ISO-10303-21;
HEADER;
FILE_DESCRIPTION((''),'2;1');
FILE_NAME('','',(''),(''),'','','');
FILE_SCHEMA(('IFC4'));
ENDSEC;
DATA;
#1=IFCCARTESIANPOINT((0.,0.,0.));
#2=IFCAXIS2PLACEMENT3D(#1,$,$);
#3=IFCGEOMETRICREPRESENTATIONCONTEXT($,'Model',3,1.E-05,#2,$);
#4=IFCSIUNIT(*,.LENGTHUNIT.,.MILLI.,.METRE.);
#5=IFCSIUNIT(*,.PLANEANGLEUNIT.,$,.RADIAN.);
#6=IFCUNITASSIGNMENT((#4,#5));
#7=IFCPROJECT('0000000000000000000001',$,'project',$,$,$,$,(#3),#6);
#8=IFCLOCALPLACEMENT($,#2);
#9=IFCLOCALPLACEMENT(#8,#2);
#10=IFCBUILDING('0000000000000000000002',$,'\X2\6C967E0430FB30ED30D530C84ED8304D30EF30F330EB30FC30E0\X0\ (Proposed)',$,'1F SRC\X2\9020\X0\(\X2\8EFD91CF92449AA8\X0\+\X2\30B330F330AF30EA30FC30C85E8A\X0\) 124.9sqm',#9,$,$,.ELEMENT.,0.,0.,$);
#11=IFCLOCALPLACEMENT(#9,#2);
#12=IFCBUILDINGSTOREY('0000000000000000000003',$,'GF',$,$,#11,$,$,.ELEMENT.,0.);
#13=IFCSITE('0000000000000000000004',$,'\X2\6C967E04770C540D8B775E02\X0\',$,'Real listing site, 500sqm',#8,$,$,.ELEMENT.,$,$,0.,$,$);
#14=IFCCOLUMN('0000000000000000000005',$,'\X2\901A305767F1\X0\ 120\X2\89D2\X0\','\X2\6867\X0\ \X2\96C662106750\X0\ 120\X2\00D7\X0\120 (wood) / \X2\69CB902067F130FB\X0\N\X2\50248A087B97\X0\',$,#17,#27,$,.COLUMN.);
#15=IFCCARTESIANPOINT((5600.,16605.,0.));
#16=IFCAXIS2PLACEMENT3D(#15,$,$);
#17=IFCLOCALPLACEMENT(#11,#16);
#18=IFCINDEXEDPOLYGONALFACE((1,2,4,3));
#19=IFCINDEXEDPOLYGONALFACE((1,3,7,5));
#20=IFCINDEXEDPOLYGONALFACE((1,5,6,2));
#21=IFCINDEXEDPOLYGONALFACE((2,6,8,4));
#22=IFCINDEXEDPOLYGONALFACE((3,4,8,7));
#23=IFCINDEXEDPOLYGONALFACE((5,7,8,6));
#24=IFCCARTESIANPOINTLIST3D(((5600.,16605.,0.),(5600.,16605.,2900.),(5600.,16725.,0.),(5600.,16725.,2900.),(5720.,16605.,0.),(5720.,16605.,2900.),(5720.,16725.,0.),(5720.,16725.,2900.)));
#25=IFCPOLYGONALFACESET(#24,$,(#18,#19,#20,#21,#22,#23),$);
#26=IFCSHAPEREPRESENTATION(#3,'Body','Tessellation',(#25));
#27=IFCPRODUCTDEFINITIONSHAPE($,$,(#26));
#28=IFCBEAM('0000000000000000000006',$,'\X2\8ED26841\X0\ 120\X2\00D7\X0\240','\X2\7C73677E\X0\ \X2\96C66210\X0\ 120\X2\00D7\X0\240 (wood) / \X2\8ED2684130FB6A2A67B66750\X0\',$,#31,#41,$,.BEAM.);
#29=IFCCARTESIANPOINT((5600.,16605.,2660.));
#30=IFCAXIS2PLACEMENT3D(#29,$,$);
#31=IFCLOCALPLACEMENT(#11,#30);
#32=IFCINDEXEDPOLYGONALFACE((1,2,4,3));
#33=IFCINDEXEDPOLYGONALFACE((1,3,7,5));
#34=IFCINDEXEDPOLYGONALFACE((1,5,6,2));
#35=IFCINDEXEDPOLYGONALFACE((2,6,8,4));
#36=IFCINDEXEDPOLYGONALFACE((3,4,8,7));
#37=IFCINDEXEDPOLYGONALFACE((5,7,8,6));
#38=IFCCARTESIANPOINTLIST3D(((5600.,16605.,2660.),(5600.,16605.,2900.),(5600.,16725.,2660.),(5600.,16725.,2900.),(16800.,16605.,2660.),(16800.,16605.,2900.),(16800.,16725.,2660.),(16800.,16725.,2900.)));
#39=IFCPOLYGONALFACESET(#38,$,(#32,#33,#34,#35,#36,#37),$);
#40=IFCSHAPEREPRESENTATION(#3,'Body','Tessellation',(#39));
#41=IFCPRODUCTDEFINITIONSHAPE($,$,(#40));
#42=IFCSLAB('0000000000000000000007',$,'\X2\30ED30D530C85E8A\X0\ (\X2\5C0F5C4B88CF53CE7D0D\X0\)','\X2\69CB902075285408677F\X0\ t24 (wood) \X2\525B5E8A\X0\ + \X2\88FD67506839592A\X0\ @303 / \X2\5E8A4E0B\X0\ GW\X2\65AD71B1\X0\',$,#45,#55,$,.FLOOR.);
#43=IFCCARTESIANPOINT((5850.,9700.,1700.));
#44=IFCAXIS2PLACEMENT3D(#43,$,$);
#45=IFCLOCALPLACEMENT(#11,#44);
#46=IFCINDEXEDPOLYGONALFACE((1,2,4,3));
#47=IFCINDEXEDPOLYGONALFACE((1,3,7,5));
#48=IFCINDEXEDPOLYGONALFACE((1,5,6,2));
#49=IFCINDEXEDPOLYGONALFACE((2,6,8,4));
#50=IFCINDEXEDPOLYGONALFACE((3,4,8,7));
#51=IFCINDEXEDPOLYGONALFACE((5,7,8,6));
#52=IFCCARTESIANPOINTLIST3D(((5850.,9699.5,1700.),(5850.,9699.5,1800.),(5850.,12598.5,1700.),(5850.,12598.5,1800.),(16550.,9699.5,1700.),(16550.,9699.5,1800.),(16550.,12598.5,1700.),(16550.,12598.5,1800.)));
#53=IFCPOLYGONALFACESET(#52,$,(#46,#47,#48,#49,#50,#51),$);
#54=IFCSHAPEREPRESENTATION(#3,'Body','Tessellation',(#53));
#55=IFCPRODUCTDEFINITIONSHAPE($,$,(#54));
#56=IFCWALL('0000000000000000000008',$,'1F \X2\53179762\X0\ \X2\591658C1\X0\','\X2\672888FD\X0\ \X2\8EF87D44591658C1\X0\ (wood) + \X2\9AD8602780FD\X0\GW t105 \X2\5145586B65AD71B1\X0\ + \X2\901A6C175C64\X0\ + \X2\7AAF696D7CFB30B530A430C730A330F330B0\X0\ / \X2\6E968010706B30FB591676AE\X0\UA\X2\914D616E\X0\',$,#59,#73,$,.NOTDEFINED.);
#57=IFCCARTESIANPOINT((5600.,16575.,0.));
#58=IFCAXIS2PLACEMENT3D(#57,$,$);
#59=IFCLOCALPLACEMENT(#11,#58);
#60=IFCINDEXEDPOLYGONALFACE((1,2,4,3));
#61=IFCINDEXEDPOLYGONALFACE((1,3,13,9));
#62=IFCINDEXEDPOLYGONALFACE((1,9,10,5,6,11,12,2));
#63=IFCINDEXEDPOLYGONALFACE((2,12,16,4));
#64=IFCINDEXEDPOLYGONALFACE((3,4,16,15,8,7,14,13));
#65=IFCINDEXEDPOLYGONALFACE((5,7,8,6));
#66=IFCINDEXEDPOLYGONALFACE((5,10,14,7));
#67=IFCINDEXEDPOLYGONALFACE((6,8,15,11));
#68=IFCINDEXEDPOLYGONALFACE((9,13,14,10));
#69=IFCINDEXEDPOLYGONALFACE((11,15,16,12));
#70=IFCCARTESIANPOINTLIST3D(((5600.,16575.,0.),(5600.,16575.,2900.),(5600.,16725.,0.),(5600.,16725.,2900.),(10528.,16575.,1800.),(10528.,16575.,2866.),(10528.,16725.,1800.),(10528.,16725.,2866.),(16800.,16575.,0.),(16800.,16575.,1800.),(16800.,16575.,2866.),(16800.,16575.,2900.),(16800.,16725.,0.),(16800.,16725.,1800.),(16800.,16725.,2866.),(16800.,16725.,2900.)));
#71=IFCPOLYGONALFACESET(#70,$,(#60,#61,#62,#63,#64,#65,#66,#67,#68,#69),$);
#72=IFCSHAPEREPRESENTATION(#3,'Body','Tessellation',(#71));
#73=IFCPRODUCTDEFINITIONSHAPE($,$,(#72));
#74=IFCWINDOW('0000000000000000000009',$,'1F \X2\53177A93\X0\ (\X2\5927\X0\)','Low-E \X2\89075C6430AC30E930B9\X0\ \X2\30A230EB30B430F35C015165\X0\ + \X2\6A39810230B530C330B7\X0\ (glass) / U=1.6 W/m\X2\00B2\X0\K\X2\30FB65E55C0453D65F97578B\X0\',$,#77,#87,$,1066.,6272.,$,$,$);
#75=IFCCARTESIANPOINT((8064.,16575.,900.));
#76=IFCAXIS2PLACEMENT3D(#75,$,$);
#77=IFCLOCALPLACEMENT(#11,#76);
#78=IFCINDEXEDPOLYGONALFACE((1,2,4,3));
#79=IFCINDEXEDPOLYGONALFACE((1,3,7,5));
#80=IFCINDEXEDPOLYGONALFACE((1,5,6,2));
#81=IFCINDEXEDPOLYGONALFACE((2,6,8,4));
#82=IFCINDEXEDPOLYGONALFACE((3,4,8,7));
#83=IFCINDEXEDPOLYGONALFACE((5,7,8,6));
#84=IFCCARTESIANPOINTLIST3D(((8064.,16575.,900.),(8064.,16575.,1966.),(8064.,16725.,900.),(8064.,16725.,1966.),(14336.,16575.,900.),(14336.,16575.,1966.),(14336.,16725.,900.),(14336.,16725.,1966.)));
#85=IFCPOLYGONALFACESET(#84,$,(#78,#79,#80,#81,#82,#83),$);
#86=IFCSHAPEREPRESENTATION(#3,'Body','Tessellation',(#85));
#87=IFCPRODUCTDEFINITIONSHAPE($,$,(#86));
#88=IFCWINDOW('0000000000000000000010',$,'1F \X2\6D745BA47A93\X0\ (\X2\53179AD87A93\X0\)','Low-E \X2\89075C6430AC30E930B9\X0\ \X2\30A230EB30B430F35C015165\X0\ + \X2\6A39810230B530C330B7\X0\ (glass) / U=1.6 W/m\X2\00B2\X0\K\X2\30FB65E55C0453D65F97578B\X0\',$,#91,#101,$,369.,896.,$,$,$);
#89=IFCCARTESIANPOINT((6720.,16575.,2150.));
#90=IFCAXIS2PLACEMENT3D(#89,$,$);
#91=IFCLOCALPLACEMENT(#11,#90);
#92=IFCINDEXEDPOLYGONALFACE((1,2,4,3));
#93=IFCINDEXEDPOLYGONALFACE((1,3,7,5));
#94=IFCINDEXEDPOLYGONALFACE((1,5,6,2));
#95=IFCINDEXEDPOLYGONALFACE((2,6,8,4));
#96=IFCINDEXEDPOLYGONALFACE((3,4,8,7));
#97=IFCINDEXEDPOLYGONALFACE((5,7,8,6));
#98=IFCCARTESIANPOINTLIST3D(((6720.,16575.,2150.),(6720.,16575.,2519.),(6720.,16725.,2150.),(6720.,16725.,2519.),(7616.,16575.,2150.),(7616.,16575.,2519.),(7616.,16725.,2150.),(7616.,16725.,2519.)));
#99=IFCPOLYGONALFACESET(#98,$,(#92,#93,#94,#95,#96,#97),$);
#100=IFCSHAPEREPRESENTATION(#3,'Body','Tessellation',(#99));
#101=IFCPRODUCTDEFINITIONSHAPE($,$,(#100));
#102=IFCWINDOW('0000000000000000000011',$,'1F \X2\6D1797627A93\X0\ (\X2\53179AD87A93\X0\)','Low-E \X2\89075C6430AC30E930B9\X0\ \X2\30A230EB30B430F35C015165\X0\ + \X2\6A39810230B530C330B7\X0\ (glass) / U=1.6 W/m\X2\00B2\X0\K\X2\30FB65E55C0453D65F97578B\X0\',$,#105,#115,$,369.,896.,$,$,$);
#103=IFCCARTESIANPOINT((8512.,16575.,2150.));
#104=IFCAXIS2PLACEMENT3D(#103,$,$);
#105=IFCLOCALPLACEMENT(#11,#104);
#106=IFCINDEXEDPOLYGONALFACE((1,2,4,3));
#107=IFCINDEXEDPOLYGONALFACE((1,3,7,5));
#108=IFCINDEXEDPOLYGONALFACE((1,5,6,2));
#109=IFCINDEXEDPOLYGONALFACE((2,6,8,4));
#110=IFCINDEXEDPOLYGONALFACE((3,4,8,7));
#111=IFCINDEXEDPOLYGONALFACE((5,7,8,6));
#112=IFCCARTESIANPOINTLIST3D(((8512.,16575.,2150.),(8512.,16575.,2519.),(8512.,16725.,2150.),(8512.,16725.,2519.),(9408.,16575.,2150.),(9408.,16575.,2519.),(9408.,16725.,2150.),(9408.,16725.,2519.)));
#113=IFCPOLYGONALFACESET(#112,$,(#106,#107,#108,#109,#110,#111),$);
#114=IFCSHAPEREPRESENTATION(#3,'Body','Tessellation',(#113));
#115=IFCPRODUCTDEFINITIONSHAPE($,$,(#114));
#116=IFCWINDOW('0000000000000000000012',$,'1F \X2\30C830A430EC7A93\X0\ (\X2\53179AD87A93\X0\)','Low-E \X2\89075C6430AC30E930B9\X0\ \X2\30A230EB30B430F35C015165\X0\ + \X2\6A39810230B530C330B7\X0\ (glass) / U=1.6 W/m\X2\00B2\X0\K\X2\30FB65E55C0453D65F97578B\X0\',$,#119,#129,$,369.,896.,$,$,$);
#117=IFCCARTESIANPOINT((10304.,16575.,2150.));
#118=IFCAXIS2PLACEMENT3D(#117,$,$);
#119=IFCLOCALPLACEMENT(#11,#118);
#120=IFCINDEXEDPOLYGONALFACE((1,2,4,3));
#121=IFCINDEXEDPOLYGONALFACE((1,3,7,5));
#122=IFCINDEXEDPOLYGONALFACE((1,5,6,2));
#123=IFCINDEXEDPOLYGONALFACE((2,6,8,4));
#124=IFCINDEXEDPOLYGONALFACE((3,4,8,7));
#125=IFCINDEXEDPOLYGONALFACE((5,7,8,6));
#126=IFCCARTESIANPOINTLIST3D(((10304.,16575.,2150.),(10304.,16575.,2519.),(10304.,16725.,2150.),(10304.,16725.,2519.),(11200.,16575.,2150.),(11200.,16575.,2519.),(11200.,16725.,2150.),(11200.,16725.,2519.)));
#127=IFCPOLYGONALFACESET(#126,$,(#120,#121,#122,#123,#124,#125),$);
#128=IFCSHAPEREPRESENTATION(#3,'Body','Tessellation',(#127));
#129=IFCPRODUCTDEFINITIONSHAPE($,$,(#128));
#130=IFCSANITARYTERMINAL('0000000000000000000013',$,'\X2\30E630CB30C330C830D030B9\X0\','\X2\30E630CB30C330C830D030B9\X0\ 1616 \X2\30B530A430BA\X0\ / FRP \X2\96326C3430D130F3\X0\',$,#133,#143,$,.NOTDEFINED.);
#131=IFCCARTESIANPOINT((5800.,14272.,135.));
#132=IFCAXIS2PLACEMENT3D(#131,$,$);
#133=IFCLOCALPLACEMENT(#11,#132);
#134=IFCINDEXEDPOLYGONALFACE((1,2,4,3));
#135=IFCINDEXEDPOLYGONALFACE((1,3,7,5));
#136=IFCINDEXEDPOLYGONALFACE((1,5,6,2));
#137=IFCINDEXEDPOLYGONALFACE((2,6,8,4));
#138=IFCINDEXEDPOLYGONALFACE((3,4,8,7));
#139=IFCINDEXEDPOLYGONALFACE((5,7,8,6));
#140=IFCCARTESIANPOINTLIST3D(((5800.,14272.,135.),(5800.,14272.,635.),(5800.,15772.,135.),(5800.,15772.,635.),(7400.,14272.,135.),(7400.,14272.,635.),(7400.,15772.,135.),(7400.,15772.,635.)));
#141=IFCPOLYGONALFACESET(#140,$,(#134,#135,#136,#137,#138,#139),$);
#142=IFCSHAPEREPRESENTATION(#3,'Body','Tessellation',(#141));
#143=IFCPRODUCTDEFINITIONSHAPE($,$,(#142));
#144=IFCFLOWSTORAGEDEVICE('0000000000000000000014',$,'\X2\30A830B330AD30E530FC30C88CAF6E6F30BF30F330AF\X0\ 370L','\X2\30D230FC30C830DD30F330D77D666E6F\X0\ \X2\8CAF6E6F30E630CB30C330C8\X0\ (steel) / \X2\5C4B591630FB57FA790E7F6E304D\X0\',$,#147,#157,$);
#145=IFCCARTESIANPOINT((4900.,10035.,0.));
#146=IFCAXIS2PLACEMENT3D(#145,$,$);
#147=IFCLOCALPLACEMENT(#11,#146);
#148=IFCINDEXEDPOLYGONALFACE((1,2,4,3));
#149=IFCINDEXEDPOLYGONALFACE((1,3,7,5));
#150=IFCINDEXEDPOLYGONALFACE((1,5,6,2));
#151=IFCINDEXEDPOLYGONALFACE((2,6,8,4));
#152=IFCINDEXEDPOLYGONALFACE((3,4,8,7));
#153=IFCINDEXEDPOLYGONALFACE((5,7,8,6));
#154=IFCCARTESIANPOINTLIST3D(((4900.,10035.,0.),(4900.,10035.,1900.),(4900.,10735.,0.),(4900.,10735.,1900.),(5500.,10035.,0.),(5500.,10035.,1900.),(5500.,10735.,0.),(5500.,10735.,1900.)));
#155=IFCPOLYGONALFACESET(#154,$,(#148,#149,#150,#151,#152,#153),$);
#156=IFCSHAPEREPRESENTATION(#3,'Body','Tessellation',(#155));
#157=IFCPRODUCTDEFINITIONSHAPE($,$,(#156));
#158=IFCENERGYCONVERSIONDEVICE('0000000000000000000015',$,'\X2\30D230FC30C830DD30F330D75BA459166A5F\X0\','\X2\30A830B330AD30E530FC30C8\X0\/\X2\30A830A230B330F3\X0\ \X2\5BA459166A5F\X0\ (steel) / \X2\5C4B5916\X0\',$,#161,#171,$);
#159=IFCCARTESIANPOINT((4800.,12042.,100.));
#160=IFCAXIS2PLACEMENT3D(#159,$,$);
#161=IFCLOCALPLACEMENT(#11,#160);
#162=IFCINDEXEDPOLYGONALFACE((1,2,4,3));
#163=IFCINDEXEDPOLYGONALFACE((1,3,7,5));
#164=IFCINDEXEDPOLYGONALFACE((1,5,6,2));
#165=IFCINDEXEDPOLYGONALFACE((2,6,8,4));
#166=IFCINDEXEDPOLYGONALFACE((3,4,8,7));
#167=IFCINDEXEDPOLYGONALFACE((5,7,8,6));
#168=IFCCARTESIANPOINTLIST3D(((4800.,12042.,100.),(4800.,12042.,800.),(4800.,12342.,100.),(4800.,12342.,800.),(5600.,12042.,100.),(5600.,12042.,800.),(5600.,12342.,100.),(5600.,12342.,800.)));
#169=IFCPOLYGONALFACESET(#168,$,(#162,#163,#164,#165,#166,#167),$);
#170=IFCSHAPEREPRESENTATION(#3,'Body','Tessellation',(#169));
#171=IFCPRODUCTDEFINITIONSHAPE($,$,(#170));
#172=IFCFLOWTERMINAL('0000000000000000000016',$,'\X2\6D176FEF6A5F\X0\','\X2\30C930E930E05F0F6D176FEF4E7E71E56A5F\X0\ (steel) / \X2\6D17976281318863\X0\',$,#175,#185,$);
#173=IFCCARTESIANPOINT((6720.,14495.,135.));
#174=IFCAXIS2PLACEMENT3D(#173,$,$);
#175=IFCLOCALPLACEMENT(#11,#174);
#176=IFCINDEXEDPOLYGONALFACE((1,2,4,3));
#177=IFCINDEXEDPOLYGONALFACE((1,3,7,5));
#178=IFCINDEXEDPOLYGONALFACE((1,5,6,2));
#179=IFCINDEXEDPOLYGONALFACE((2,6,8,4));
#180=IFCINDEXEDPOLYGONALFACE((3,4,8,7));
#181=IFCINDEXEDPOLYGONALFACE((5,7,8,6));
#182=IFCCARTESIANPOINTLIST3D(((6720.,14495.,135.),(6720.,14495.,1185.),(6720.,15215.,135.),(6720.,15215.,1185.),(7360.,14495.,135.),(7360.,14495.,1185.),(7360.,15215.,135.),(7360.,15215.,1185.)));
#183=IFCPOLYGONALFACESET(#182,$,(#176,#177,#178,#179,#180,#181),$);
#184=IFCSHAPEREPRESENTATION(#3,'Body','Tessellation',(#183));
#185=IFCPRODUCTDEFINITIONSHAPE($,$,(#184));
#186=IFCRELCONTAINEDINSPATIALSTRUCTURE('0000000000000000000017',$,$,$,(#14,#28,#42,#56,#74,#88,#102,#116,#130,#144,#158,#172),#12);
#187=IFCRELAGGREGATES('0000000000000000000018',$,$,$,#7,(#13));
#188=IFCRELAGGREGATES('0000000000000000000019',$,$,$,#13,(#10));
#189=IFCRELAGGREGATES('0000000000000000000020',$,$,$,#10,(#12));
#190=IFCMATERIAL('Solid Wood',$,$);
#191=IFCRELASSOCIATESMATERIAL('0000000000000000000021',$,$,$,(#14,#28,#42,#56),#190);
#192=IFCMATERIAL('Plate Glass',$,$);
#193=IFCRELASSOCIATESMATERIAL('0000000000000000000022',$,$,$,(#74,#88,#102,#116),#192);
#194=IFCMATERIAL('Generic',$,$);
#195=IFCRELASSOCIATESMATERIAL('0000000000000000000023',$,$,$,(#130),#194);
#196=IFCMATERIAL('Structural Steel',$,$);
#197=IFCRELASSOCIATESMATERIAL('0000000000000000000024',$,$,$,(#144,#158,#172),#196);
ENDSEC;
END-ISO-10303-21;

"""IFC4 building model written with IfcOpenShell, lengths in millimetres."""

from ifc_helpers import new_model, si_unit, frame, frame_2d, origin, place, context, project, spatial, rectangle, extrude, material, element, fill, save


model = new_model("IFC4")

# Units and contexts
model_context = context("Model", 3, precision=1e-05, world=origin())
ifc_project = project(units=[si_unit("LENGTHUNIT", "METRE", prefix="MILLI"), si_unit("PLANEANGLEUNIT", "RADIAN")], contexts=[model_context])

# Site, building, storey
site_placement = place(None, origin())
site = spatial("IfcSite", under=ifc_project, at=site_placement, Name="沖縄県名護市", ObjectType="Real listing site, 500sqm", CompositionType="ELEMENT", RefElevation=0.0)
building_placement = place(site_placement, origin())
building = spatial("IfcBuilding", under=site, at=building_placement, Name="沖縄・ロフト付きワンルーム (Proposed)", ObjectType="1F SRC造(軽量鉄骨+コンクリート床) 124.9sqm", CompositionType="ELEMENT", ElevationOfRefHeight=0.0, ElevationOfTerrain=0.0)
storey_placement = place(building_placement, origin())
storey = spatial("IfcBuildingStorey", under=building, at=storey_placement, Name="GF", CompositionType="ELEMENT", Elevation=0.0)

# Column
ifc_material_1 = material(Name="Solid Wood")
column_1_placement = place(storey_placement, frame((5600.0, 16605.0, 0.0)))
element("IfcColumn", 1, at=column_1_placement, inside=storey, material=ifc_material_1, Name="通し柱 120角", Description="桧 集成材 120×120 (wood) / 構造柱・N値計算", PredefinedType="COLUMN", context=model_context, shape_type="SweptSolid", body=[
    extrude(rectangle(XDim=120.0, YDim=120.0, at=frame_2d((60.0, 60.0))), frame((5600.0, 16605.0, 0.0)), (0.0, 0.0, 1.0), 2900.0),
])

# Beam
beam_1_placement = place(storey_placement, frame((5600.0, 16605.0, 2660.0)))
element("IfcBeam", 2, at=beam_1_placement, inside=storey, material=ifc_material_1, Name="軒桁 120×240", Description="米松 集成 120×240 (wood) / 軒桁・横架材", PredefinedType="BEAM", context=model_context, shape_type="SweptSolid", body=[
    extrude(rectangle(XDim=11200.0, YDim=120.0, at=frame_2d((5600.0, 60.0))), frame((5600.0, 16605.0, 2660.0)), (0.0, 0.0, 1.0), 240.0),
])

# Slab
slab_placement = place(storey_placement, frame((5850.0, 9700.0, 1700.0)))
element("IfcSlab", 3, at=slab_placement, inside=storey, material=ifc_material_1, Name="ロフト床 (小屋裏収納)", Description="構造用合板 t24 (wood) 剛床 + 製材根太 @303 / 床下 GW断熱", PredefinedType="FLOOR", context=model_context, shape_type="SweptSolid", body=[
    extrude(rectangle(XDim=10700.0, YDim=2899.0, at=frame_2d((5350.0, 1449.0))), frame((5850.0, 9700.0, 1700.0)), (0.0, 0.0, 1.0), 100.0),
])

# Wall, openings, windows
wall_1_placement = place(storey_placement, frame((5600.0, 16575.0, 0.0)))
wall_1 = element("IfcWall", 4, at=wall_1_placement, inside=storey, material=ifc_material_1, Name="1F 北面 外壁", Description="木製 軸組外壁 (wood) + 高性能GW t105 充填断熱 + 通気層 + 窯業系サイディング / 準耐火・外皮UA配慮", PredefinedType="NOTDEFINED", context=model_context, shape_type="SweptSolid", body=[
    extrude(rectangle(XDim=11200.0, YDim=150.0, at=frame_2d((5600.0, 75.0))), frame((5600.0, 16575.0, 0.0)), (0.0, 0.0, 1.0), 2900.0),
])
opening_1_placement = place(storey_placement, frame((8064.0, 16575.0, 900.0)))
opening_1 = element("IfcOpeningElement", 5, at=opening_1_placement, cuts=wall_1, PredefinedType="NOTDEFINED", context=model_context, shape_type="SweptSolid", body=[
    extrude(rectangle(XDim=6272.0, YDim=150.0, at=frame_2d((3136.0, 75.0))), frame((8064.0, 16575.0, 900.0)), (0.0, 0.0, 1.0), 1066.0),
])
opening_2_placement = place(storey_placement, frame((6720.0, 16575.0, 2150.0)))
opening_2 = element("IfcOpeningElement", 6, at=opening_2_placement, cuts=wall_1, PredefinedType="NOTDEFINED", context=model_context, shape_type="SweptSolid", body=[
    extrude(rectangle(XDim=896.0, YDim=150.0, at=frame_2d((448.0, 75.0))), frame((6720.0, 16575.0, 2150.0)), (0.0, 0.0, 1.0), 369.0),
])
opening_3_placement = place(storey_placement, frame((8512.0, 16575.0, 2150.0)))
opening_3 = element("IfcOpeningElement", 7, at=opening_3_placement, cuts=wall_1, PredefinedType="NOTDEFINED", context=model_context, shape_type="SweptSolid", body=[
    extrude(rectangle(XDim=896.0, YDim=150.0, at=frame_2d((448.0, 75.0))), frame((8512.0, 16575.0, 2150.0)), (0.0, 0.0, 1.0), 369.0),
])
opening_4_placement = place(storey_placement, frame((10304.0, 16575.0, 2150.0)))
opening_4 = element("IfcOpeningElement", 8, at=opening_4_placement, cuts=wall_1, PredefinedType="NOTDEFINED", context=model_context, shape_type="SweptSolid", body=[
    extrude(rectangle(XDim=896.0, YDim=150.0, at=frame_2d((448.0, 75.0))), frame((10304.0, 16575.0, 2150.0)), (0.0, 0.0, 1.0), 369.0),
])
ifc_material_2 = material(Name="Plate Glass")
window_1_placement = place(storey_placement, frame((8064.0, 16575.0, 900.0)))
window_1 = element("IfcWindow", 9, at=window_1_placement, inside=storey, material=ifc_material_2, Name="1F 北窓 (大)", Description="Low-E 複層ガラス アルゴン封入 + 樹脂サッシ (glass) / U=1.6 W/m²K・日射取得型", OverallHeight=1066.0, OverallWidth=6272.0, context=model_context, shape_type="SweptSolid", body=[
    extrude(rectangle(XDim=6272.0, YDim=150.0, at=frame_2d((3136.0, 75.0))), frame((8064.0, 16575.0, 900.0)), (0.0, 0.0, 1.0), 1066.0),
])
fill(opening_1, window_1)
window_2_placement = place(storey_placement, frame((6720.0, 16575.0, 2150.0)))
window_2 = element("IfcWindow", 10, at=window_2_placement, inside=storey, material=ifc_material_2, Name="1F 浴室窓 (北高窓)", Description="Low-E 複層ガラス アルゴン封入 + 樹脂サッシ (glass) / U=1.6 W/m²K・日射取得型", OverallHeight=369.0, OverallWidth=896.0, context=model_context, shape_type="SweptSolid", body=[
    extrude(rectangle(XDim=896.0, YDim=150.0, at=frame_2d((448.0, 75.0))), frame((6720.0, 16575.0, 2150.0)), (0.0, 0.0, 1.0), 369.0),
])
fill(opening_2, window_2)
window_3_placement = place(storey_placement, frame((8512.0, 16575.0, 2150.0)))
window_3 = element("IfcWindow", 11, at=window_3_placement, inside=storey, material=ifc_material_2, Name="1F 洗面窓 (北高窓)", Description="Low-E 複層ガラス アルゴン封入 + 樹脂サッシ (glass) / U=1.6 W/m²K・日射取得型", OverallHeight=369.0, OverallWidth=896.0, context=model_context, shape_type="SweptSolid", body=[
    extrude(rectangle(XDim=896.0, YDim=150.0, at=frame_2d((448.0, 75.0))), frame((8512.0, 16575.0, 2150.0)), (0.0, 0.0, 1.0), 369.0),
])
fill(opening_3, window_3)
window_4_placement = place(storey_placement, frame((10304.0, 16575.0, 2150.0)))
window_4 = element("IfcWindow", 12, at=window_4_placement, inside=storey, material=ifc_material_2, Name="1F トイレ窓 (北高窓)", Description="Low-E 複層ガラス アルゴン封入 + 樹脂サッシ (glass) / U=1.6 W/m²K・日射取得型", OverallHeight=369.0, OverallWidth=896.0, context=model_context, shape_type="SweptSolid", body=[
    extrude(rectangle(XDim=896.0, YDim=150.0, at=frame_2d((448.0, 75.0))), frame((10304.0, 16575.0, 2150.0)), (0.0, 0.0, 1.0), 369.0),
])
fill(opening_4, window_4)

# Sanitary terminal
ifc_material_3 = material(Name="Generic")
sanitary_terminal_placement = place(storey_placement, frame((5800.0, 14272.0, 135.0)))
element("IfcSanitaryTerminal", 13, at=sanitary_terminal_placement, inside=storey, material=ifc_material_3, Name="ユニットバス", Description="ユニットバス 1616 サイズ / FRP 防水パン", PredefinedType="NOTDEFINED", context=model_context, shape_type="SweptSolid", body=[
    extrude(rectangle(XDim=1600.0, YDim=1500.0, at=frame_2d((800.0, 750.0))), frame((5800.0, 14272.0, 135.0)), (0.0, 0.0, 1.0), 500.0),
])

# Flow storage device
ifc_material_4 = material(Name="Structural Steel")
flow_storage_device_placement = place(storey_placement, frame((4900.0, 10035.0, 0.0)))
element("IfcFlowStorageDevice", 14, at=flow_storage_device_placement, inside=storey, material=ifc_material_4, Name="エコキュート貯湯タンク 370L", Description="ヒートポンプ給湯 貯湯ユニット (steel) / 屋外・基礎置き", context=model_context, shape_type="SweptSolid", body=[
    extrude(rectangle(XDim=600.0, YDim=700.0, at=frame_2d((300.0, 350.0))), frame((4900.0, 10035.0, 0.0)), (0.0, 0.0, 1.0), 1900.0),
])

# Energy conversion device
energy_conversion_device_placement = place(storey_placement, frame((4800.0, 12042.0, 100.0)))
element("IfcEnergyConversionDevice", 15, at=energy_conversion_device_placement, inside=storey, material=ifc_material_4, Name="ヒートポンプ室外機", Description="エコキュート/エアコン 室外機 (steel) / 屋外", context=model_context, shape_type="SweptSolid", body=[
    extrude(rectangle(XDim=800.0, YDim=300.0, at=frame_2d((400.0, 150.0))), frame((4800.0, 12042.0, 100.0)), (0.0, 0.0, 1.0), 700.0),
])

# Flow terminal
flow_terminal_placement = place(storey_placement, frame((6720.0, 14495.0, 135.0)))
element("IfcFlowTerminal", 16, at=flow_terminal_placement, inside=storey, material=ifc_material_4, Name="洗濯機", Description="ドラム式洗濯乾燥機 (steel) / 洗面脱衣", context=model_context, shape_type="SweptSolid", body=[
    extrude(rectangle(XDim=640.0, YDim=720.0, at=frame_2d((320.0, 360.0))), frame((6720.0, 14495.0, 135.0)), (0.0, 0.0, 1.0), 1050.0),
])

save(model, "model.ifc")
